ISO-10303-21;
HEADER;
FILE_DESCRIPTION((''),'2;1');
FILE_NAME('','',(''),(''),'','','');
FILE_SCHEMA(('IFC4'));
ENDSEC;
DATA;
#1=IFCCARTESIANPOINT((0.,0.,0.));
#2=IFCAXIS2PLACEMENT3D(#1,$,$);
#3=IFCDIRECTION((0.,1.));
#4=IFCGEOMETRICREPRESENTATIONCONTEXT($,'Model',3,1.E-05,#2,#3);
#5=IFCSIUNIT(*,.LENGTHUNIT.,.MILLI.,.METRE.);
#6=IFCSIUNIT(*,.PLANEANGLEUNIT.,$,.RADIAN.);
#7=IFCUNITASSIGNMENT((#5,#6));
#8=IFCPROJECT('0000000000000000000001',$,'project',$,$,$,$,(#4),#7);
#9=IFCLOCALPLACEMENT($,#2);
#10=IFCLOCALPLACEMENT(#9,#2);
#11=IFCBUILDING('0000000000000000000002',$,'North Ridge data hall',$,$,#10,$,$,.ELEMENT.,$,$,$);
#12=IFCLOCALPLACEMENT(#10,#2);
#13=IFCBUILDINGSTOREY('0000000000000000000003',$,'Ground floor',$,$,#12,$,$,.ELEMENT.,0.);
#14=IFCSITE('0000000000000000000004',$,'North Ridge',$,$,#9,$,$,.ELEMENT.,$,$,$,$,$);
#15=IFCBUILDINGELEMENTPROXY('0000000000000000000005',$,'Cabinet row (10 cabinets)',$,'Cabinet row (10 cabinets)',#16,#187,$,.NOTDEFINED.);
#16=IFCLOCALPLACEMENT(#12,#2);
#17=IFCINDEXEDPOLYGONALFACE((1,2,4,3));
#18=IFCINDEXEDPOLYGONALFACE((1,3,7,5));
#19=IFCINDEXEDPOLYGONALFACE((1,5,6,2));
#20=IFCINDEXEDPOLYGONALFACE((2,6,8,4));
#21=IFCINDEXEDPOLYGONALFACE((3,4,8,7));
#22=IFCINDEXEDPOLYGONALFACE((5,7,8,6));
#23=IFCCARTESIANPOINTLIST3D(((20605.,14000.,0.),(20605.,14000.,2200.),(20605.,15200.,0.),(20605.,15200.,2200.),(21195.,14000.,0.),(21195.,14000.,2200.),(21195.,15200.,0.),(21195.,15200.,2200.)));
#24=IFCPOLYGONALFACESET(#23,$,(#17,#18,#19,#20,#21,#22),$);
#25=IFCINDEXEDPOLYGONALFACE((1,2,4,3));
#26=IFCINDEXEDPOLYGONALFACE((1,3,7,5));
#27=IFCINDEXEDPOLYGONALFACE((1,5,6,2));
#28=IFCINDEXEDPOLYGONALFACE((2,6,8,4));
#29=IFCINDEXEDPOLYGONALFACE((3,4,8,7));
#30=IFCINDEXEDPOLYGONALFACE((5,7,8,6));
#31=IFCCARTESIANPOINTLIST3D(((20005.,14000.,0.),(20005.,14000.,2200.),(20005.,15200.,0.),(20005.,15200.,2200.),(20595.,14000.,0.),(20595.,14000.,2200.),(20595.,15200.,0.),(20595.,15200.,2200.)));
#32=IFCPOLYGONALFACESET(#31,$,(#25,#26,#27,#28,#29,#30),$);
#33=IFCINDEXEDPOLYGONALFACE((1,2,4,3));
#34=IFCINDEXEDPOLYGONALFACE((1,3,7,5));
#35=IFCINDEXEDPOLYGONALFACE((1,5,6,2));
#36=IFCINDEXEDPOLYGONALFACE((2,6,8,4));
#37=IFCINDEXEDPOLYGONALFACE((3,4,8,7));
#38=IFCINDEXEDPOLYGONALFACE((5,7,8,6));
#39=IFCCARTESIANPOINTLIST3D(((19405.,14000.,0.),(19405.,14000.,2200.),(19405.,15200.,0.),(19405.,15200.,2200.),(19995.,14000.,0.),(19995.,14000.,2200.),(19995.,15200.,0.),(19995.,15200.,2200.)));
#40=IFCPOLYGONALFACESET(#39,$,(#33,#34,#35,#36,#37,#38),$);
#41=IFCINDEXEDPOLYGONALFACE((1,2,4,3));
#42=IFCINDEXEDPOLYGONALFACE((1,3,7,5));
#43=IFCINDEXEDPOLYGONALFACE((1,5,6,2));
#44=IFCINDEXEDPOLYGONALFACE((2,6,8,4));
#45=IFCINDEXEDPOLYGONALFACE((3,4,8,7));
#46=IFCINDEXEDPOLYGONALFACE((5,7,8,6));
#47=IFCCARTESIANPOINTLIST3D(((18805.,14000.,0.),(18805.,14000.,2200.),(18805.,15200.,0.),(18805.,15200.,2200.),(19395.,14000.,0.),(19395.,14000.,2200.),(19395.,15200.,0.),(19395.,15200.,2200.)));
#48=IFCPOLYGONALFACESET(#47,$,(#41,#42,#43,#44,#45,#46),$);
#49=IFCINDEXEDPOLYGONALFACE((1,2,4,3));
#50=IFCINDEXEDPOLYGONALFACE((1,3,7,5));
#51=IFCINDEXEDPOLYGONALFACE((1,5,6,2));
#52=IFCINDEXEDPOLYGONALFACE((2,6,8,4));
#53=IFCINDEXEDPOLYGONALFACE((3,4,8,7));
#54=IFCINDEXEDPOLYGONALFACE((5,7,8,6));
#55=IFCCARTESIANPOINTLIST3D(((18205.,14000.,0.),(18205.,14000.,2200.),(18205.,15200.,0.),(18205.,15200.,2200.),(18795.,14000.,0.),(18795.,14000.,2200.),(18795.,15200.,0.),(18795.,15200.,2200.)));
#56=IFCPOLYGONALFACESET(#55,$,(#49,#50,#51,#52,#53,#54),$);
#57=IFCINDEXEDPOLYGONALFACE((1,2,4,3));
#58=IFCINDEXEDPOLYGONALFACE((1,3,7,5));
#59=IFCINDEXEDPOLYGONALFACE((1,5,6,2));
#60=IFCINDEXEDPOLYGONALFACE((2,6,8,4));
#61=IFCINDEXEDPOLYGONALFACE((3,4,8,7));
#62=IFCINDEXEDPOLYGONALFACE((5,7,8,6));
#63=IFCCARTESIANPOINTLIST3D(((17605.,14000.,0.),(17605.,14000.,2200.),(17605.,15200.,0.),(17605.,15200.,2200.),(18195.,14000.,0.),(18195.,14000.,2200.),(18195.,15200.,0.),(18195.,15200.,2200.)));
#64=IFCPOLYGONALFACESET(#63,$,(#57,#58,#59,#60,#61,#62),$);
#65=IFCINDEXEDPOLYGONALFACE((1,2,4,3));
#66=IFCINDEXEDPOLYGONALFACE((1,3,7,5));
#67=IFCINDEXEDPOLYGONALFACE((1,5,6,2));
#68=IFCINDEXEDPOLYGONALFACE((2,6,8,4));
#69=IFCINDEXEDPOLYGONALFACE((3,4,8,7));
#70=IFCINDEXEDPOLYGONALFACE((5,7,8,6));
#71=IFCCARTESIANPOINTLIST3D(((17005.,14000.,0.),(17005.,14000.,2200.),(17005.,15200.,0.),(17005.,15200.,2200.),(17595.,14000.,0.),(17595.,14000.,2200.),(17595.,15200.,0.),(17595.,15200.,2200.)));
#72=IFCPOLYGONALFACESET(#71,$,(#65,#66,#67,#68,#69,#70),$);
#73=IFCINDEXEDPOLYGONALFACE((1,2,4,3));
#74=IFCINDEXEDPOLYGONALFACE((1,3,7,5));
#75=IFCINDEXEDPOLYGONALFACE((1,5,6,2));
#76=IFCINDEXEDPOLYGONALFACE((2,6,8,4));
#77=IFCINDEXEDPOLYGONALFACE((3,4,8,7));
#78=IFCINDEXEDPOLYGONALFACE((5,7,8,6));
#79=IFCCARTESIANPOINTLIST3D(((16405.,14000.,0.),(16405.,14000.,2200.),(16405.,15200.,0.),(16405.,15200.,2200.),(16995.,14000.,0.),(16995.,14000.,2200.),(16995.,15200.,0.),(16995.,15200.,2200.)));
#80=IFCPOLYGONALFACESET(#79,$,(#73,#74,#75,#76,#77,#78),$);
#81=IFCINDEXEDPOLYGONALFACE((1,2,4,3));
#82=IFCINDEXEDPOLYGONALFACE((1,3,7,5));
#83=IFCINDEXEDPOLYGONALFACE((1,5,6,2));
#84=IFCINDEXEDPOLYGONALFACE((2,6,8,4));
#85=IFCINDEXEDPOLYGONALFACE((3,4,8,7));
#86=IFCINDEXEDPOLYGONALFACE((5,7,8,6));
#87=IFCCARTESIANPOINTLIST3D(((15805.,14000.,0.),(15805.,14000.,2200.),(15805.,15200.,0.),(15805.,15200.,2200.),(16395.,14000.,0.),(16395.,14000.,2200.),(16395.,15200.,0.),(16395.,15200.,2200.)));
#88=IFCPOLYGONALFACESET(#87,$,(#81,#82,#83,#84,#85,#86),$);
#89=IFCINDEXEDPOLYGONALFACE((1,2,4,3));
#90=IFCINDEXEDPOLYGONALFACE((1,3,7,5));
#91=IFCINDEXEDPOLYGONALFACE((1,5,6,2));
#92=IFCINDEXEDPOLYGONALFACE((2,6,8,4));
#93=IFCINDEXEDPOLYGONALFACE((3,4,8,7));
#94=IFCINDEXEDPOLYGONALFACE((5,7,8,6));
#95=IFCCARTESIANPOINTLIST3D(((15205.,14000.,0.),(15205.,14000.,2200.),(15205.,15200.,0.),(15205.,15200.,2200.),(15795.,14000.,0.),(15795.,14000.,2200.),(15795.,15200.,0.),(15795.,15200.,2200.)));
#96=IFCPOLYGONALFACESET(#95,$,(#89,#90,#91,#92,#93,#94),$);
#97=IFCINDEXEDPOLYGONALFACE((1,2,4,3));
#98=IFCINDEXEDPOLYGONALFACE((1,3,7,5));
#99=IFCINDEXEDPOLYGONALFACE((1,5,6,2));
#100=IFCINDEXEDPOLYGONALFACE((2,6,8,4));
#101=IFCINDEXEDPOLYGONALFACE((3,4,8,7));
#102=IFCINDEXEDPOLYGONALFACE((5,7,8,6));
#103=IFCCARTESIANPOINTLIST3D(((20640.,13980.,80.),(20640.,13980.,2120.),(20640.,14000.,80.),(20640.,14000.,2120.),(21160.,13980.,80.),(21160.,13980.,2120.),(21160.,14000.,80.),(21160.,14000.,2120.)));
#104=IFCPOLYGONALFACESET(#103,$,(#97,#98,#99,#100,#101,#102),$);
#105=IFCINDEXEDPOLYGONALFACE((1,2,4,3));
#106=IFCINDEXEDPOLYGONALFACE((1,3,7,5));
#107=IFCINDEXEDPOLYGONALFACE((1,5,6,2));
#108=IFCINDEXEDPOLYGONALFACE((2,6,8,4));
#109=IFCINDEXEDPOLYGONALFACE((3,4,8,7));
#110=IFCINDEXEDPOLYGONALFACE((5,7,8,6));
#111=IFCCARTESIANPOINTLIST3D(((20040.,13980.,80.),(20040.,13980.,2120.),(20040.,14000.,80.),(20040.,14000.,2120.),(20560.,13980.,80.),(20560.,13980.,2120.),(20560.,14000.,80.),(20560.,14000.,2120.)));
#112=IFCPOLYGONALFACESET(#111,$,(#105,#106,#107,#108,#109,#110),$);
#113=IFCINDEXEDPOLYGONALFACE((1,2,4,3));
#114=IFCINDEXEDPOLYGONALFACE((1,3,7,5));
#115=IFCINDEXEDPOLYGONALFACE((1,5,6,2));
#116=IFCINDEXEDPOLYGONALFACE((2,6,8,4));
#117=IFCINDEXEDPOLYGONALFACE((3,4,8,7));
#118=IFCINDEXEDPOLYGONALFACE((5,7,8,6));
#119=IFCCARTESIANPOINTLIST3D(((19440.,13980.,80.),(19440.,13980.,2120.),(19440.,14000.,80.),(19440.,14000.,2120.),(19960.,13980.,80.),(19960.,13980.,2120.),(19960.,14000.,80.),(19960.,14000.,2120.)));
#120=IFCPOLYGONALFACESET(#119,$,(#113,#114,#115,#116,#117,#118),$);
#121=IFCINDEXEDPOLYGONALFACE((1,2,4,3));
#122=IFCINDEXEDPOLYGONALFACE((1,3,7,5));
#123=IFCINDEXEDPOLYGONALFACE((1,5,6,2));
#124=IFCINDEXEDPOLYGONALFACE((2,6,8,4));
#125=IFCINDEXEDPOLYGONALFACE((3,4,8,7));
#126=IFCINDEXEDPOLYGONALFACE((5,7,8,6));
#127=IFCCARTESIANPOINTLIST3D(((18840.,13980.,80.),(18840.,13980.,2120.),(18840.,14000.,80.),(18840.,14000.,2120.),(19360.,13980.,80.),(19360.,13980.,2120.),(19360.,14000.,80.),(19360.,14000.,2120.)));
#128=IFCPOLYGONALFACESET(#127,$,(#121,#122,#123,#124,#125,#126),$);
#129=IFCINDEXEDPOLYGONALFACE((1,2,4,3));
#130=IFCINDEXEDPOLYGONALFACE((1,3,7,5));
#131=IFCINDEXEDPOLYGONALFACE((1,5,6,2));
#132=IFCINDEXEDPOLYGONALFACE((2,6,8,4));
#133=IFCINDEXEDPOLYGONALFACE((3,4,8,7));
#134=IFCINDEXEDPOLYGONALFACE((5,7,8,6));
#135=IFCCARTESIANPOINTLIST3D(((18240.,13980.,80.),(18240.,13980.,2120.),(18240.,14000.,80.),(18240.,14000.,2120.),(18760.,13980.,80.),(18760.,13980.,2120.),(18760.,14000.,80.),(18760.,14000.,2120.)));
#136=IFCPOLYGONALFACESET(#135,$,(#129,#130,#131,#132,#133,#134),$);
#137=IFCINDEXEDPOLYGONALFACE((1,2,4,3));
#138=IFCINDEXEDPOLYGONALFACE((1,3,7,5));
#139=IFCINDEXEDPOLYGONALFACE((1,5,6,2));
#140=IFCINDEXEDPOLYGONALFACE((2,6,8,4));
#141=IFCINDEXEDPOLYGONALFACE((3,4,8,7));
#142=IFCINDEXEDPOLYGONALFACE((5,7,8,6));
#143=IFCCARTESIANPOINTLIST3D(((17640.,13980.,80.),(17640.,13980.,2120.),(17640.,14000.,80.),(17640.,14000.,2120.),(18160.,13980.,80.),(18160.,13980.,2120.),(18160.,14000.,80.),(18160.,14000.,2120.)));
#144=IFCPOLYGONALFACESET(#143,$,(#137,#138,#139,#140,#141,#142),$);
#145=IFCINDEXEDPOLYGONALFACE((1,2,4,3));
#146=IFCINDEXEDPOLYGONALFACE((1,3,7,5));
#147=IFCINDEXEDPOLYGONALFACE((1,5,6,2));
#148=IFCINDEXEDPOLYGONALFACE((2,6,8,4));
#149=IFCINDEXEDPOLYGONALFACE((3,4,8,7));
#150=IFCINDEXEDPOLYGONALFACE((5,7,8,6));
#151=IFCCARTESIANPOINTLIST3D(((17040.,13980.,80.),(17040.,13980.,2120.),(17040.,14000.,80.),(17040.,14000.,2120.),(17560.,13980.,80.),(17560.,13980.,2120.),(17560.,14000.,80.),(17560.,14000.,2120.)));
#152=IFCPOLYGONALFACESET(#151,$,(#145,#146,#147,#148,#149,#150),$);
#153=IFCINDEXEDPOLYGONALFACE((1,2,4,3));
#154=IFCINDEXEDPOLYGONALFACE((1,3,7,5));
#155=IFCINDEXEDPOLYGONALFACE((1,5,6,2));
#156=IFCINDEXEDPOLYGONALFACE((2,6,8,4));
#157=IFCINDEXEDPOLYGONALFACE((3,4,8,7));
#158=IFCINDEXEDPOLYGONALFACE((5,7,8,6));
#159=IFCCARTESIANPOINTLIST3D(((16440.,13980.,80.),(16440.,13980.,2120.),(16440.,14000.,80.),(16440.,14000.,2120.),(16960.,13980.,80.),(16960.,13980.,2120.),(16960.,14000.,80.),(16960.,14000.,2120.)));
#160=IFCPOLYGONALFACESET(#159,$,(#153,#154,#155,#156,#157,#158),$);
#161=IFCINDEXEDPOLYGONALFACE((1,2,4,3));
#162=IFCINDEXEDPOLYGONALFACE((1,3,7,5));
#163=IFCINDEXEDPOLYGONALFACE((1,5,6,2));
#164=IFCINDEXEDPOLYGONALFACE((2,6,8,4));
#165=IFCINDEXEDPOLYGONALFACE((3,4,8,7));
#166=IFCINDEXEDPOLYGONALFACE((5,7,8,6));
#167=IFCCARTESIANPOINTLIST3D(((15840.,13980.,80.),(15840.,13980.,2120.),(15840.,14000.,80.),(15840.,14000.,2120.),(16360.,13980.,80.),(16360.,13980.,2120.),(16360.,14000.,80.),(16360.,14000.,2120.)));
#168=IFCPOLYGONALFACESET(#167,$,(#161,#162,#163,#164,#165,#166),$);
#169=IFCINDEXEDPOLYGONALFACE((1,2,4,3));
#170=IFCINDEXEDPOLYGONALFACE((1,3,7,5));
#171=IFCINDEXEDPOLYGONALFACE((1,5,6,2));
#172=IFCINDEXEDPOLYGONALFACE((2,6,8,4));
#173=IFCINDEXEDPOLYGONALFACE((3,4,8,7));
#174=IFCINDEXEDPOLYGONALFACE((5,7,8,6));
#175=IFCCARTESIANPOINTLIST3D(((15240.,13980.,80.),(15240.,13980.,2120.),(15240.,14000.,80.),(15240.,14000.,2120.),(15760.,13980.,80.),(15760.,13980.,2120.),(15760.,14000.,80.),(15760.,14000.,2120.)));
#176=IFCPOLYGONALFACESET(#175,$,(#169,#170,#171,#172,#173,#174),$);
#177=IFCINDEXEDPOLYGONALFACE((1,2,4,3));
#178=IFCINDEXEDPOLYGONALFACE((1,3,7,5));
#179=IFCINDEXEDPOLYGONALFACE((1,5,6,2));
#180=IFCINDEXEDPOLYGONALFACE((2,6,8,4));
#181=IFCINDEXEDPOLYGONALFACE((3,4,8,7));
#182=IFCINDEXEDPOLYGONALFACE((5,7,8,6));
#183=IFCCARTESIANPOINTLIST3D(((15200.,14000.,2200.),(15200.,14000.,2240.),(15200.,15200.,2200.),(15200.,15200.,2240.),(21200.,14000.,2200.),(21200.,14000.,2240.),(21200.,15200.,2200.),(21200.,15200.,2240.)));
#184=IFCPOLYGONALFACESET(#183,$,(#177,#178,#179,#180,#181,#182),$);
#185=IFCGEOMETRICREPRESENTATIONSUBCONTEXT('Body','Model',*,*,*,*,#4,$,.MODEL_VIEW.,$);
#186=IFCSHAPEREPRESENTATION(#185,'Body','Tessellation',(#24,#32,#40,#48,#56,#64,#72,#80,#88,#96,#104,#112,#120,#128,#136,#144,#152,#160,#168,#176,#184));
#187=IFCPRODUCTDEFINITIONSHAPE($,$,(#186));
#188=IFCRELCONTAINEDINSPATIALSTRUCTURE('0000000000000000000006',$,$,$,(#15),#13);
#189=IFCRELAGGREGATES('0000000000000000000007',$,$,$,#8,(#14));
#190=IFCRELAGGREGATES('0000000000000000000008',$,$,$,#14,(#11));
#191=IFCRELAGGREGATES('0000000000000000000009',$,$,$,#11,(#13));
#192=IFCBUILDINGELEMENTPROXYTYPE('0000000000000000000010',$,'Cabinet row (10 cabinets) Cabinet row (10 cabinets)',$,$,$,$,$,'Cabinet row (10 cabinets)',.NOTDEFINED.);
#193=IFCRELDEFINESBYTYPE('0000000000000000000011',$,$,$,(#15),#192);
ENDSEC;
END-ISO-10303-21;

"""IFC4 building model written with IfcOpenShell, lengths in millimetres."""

from ifc_helpers import new_model, si_unit, direction, frame, origin, place, context, subcontext, project, spatial, polyline, outline, extrude, source, transform, mapped, type_object, type_shapes, element, save


model = new_model("IFC4")

# Units and contexts
model_context = context("Model", 3, precision=1e-05, world=origin(), true_north=direction((0.0, 1.0)))
body_context = subcontext(model_context, "Body", "Model", "MODEL_VIEW")
ifc_project = project(units=[si_unit("LENGTHUNIT", "METRE", prefix="MILLI"), si_unit("PLANEANGLEUNIT", "RADIAN")], contexts=[model_context])

# Site, building, storey
site_placement = place(None, origin())
site = spatial("IfcSite", under=ifc_project, at=site_placement, Name="North Ridge", CompositionType="ELEMENT")
building_placement = place(site_placement, origin())
building = spatial("IfcBuilding", under=site, at=building_placement, Name="North Ridge data hall", CompositionType="ELEMENT")
storey_placement = place(building_placement, origin())
storey = spatial("IfcBuildingStorey", under=building, at=storey_placement, Name="Ground floor", CompositionType="ELEMENT", Elevation=0.0)

# Building element proxy
building_element_proxy_type_1 = type_object("IfcBuildingElementProxyType", Name="Cabinet row (10 cabinets) Cabinet row (10 cabinets)", ElementType="Cabinet row (10 cabinets)", PredefinedType="NOTDEFINED")
shared_shape_1 = source(origin(), body_context, "Body", "SweptSolid", [
    extrude(outline(polyline([(5.0, 0.0), (595.0, 0.0), (595.0, 1200.0), (5.0, 1200.0), (5.0, 0.0)])), origin(), (0.0, 0.0, 1.0), 2200.0),
    extrude(outline(polyline([(605.0, 0.0), (1195.0, 0.0), (1195.0, 1200.0), (605.0, 1200.0), (605.0, 0.0)])), origin(), (0.0, 0.0, 1.0), 2200.0),
    extrude(outline(polyline([(1205.0, 0.0), (1795.0, 0.0), (1795.0, 1200.0), (1205.0, 1200.0), (1205.0, 0.0)])), origin(), (0.0, 0.0, 1.0), 2200.0),
    extrude(outline(polyline([(1805.0, 0.0), (2395.0, 0.0), (2395.0, 1200.0), (1805.0, 1200.0), (1805.0, 0.0)])), origin(), (0.0, 0.0, 1.0), 2200.0),
    extrude(outline(polyline([(2405.0, 0.0), (2995.0, 0.0), (2995.0, 1200.0), (2405.0, 1200.0), (2405.0, 0.0)])), origin(), (0.0, 0.0, 1.0), 2200.0),
    extrude(outline(polyline([(3005.0, 0.0), (3595.0, 0.0), (3595.0, 1200.0), (3005.0, 1200.0), (3005.0, 0.0)])), origin(), (0.0, 0.0, 1.0), 2200.0),
    extrude(outline(polyline([(3605.0, 0.0), (4195.0, 0.0), (4195.0, 1200.0), (3605.0, 1200.0), (3605.0, 0.0)])), origin(), (0.0, 0.0, 1.0), 2200.0),
    extrude(outline(polyline([(4205.0, 0.0), (4795.0, 0.0), (4795.0, 1200.0), (4205.0, 1200.0), (4205.0, 0.0)])), origin(), (0.0, 0.0, 1.0), 2200.0),
    extrude(outline(polyline([(4805.0, 0.0), (5395.0, 0.0), (5395.0, 1200.0), (4805.0, 1200.0), (4805.0, 0.0)])), origin(), (0.0, 0.0, 1.0), 2200.0),
    extrude(outline(polyline([(5405.0, 0.0), (5995.0, 0.0), (5995.0, 1200.0), (5405.0, 1200.0), (5405.0, 0.0)])), origin(), (0.0, 0.0, 1.0), 2200.0),
    extrude(outline(polyline([(40.0, 1200.0), (560.0, 1200.0), (560.0, 1220.0), (40.0, 1220.0), (40.0, 1200.0)])), frame((0.0, 0.0, 80.0)), (0.0, 0.0, 1.0), 2040.0),
    extrude(outline(polyline([(640.0, 1200.0), (1160.0, 1200.0), (1160.0, 1220.0), (640.0, 1220.0), (640.0, 1200.0)])), frame((0.0, 0.0, 80.0)), (0.0, 0.0, 1.0), 2040.0),
    extrude(outline(polyline([(1240.0, 1200.0), (1760.0, 1200.0), (1760.0, 1220.0), (1240.0, 1220.0), (1240.0, 1200.0)])), frame((0.0, 0.0, 80.0)), (0.0, 0.0, 1.0), 2040.0),
    extrude(outline(polyline([(1840.0, 1200.0), (2360.0, 1200.0), (2360.0, 1220.0), (1840.0, 1220.0), (1840.0, 1200.0)])), frame((0.0, 0.0, 80.0)), (0.0, 0.0, 1.0), 2040.0),
    extrude(outline(polyline([(2440.0, 1200.0), (2960.0, 1200.0), (2960.0, 1220.0), (2440.0, 1220.0), (2440.0, 1200.0)])), frame((0.0, 0.0, 80.0)), (0.0, 0.0, 1.0), 2040.0),
    extrude(outline(polyline([(3040.0, 1200.0), (3560.0, 1200.0), (3560.0, 1220.0), (3040.0, 1220.0), (3040.0, 1200.0)])), frame((0.0, 0.0, 80.0)), (0.0, 0.0, 1.0), 2040.0),
    extrude(outline(polyline([(3640.0, 1200.0), (4160.0, 1200.0), (4160.0, 1220.0), (3640.0, 1220.0), (3640.0, 1200.0)])), frame((0.0, 0.0, 80.0)), (0.0, 0.0, 1.0), 2040.0),
    extrude(outline(polyline([(4240.0, 1200.0), (4760.0, 1200.0), (4760.0, 1220.0), (4240.0, 1220.0), (4240.0, 1200.0)])), frame((0.0, 0.0, 80.0)), (0.0, 0.0, 1.0), 2040.0),
    extrude(outline(polyline([(4840.0, 1200.0), (5360.0, 1200.0), (5360.0, 1220.0), (4840.0, 1220.0), (4840.0, 1200.0)])), frame((0.0, 0.0, 80.0)), (0.0, 0.0, 1.0), 2040.0),
    extrude(outline(polyline([(5440.0, 1200.0), (5960.0, 1200.0), (5960.0, 1220.0), (5440.0, 1220.0), (5440.0, 1200.0)])), frame((0.0, 0.0, 80.0)), (0.0, 0.0, 1.0), 2040.0),
    extrude(outline(polyline([(0.0, 0.0), (6000.0, 0.0), (6000.0, 1200.0), (0.0, 1200.0), (0.0, 0.0)])), frame((0.0, 0.0, 2200.0)), (0.0, 0.0, 1.0), 40.0),
])
type_shapes(building_element_proxy_type_1, [shared_shape_1])
for number, where, z_axis, x_axis, name in (
    (1, (21200.0, 15200.0, 0.0), (0.0, 0.0, 1.0), (-1.0, 0.0, 0.0), "Cabinet row (10 cabinets)"),
):
    element("IfcBuildingElementProxy", number, at=place(storey_placement, frame(where, z_axis=z_axis, x_axis=x_axis)), inside=storey, type_object=building_element_proxy_type_1, Name=name, ObjectType="Cabinet row (10 cabinets)", PredefinedType="NOTDEFINED", context=body_context, shape_type="MappedRepresentation", body=[
        mapped(shared_shape_1, transform((0.0, 0.0, 0.0))),
    ])

save(model, "model.ifc")
